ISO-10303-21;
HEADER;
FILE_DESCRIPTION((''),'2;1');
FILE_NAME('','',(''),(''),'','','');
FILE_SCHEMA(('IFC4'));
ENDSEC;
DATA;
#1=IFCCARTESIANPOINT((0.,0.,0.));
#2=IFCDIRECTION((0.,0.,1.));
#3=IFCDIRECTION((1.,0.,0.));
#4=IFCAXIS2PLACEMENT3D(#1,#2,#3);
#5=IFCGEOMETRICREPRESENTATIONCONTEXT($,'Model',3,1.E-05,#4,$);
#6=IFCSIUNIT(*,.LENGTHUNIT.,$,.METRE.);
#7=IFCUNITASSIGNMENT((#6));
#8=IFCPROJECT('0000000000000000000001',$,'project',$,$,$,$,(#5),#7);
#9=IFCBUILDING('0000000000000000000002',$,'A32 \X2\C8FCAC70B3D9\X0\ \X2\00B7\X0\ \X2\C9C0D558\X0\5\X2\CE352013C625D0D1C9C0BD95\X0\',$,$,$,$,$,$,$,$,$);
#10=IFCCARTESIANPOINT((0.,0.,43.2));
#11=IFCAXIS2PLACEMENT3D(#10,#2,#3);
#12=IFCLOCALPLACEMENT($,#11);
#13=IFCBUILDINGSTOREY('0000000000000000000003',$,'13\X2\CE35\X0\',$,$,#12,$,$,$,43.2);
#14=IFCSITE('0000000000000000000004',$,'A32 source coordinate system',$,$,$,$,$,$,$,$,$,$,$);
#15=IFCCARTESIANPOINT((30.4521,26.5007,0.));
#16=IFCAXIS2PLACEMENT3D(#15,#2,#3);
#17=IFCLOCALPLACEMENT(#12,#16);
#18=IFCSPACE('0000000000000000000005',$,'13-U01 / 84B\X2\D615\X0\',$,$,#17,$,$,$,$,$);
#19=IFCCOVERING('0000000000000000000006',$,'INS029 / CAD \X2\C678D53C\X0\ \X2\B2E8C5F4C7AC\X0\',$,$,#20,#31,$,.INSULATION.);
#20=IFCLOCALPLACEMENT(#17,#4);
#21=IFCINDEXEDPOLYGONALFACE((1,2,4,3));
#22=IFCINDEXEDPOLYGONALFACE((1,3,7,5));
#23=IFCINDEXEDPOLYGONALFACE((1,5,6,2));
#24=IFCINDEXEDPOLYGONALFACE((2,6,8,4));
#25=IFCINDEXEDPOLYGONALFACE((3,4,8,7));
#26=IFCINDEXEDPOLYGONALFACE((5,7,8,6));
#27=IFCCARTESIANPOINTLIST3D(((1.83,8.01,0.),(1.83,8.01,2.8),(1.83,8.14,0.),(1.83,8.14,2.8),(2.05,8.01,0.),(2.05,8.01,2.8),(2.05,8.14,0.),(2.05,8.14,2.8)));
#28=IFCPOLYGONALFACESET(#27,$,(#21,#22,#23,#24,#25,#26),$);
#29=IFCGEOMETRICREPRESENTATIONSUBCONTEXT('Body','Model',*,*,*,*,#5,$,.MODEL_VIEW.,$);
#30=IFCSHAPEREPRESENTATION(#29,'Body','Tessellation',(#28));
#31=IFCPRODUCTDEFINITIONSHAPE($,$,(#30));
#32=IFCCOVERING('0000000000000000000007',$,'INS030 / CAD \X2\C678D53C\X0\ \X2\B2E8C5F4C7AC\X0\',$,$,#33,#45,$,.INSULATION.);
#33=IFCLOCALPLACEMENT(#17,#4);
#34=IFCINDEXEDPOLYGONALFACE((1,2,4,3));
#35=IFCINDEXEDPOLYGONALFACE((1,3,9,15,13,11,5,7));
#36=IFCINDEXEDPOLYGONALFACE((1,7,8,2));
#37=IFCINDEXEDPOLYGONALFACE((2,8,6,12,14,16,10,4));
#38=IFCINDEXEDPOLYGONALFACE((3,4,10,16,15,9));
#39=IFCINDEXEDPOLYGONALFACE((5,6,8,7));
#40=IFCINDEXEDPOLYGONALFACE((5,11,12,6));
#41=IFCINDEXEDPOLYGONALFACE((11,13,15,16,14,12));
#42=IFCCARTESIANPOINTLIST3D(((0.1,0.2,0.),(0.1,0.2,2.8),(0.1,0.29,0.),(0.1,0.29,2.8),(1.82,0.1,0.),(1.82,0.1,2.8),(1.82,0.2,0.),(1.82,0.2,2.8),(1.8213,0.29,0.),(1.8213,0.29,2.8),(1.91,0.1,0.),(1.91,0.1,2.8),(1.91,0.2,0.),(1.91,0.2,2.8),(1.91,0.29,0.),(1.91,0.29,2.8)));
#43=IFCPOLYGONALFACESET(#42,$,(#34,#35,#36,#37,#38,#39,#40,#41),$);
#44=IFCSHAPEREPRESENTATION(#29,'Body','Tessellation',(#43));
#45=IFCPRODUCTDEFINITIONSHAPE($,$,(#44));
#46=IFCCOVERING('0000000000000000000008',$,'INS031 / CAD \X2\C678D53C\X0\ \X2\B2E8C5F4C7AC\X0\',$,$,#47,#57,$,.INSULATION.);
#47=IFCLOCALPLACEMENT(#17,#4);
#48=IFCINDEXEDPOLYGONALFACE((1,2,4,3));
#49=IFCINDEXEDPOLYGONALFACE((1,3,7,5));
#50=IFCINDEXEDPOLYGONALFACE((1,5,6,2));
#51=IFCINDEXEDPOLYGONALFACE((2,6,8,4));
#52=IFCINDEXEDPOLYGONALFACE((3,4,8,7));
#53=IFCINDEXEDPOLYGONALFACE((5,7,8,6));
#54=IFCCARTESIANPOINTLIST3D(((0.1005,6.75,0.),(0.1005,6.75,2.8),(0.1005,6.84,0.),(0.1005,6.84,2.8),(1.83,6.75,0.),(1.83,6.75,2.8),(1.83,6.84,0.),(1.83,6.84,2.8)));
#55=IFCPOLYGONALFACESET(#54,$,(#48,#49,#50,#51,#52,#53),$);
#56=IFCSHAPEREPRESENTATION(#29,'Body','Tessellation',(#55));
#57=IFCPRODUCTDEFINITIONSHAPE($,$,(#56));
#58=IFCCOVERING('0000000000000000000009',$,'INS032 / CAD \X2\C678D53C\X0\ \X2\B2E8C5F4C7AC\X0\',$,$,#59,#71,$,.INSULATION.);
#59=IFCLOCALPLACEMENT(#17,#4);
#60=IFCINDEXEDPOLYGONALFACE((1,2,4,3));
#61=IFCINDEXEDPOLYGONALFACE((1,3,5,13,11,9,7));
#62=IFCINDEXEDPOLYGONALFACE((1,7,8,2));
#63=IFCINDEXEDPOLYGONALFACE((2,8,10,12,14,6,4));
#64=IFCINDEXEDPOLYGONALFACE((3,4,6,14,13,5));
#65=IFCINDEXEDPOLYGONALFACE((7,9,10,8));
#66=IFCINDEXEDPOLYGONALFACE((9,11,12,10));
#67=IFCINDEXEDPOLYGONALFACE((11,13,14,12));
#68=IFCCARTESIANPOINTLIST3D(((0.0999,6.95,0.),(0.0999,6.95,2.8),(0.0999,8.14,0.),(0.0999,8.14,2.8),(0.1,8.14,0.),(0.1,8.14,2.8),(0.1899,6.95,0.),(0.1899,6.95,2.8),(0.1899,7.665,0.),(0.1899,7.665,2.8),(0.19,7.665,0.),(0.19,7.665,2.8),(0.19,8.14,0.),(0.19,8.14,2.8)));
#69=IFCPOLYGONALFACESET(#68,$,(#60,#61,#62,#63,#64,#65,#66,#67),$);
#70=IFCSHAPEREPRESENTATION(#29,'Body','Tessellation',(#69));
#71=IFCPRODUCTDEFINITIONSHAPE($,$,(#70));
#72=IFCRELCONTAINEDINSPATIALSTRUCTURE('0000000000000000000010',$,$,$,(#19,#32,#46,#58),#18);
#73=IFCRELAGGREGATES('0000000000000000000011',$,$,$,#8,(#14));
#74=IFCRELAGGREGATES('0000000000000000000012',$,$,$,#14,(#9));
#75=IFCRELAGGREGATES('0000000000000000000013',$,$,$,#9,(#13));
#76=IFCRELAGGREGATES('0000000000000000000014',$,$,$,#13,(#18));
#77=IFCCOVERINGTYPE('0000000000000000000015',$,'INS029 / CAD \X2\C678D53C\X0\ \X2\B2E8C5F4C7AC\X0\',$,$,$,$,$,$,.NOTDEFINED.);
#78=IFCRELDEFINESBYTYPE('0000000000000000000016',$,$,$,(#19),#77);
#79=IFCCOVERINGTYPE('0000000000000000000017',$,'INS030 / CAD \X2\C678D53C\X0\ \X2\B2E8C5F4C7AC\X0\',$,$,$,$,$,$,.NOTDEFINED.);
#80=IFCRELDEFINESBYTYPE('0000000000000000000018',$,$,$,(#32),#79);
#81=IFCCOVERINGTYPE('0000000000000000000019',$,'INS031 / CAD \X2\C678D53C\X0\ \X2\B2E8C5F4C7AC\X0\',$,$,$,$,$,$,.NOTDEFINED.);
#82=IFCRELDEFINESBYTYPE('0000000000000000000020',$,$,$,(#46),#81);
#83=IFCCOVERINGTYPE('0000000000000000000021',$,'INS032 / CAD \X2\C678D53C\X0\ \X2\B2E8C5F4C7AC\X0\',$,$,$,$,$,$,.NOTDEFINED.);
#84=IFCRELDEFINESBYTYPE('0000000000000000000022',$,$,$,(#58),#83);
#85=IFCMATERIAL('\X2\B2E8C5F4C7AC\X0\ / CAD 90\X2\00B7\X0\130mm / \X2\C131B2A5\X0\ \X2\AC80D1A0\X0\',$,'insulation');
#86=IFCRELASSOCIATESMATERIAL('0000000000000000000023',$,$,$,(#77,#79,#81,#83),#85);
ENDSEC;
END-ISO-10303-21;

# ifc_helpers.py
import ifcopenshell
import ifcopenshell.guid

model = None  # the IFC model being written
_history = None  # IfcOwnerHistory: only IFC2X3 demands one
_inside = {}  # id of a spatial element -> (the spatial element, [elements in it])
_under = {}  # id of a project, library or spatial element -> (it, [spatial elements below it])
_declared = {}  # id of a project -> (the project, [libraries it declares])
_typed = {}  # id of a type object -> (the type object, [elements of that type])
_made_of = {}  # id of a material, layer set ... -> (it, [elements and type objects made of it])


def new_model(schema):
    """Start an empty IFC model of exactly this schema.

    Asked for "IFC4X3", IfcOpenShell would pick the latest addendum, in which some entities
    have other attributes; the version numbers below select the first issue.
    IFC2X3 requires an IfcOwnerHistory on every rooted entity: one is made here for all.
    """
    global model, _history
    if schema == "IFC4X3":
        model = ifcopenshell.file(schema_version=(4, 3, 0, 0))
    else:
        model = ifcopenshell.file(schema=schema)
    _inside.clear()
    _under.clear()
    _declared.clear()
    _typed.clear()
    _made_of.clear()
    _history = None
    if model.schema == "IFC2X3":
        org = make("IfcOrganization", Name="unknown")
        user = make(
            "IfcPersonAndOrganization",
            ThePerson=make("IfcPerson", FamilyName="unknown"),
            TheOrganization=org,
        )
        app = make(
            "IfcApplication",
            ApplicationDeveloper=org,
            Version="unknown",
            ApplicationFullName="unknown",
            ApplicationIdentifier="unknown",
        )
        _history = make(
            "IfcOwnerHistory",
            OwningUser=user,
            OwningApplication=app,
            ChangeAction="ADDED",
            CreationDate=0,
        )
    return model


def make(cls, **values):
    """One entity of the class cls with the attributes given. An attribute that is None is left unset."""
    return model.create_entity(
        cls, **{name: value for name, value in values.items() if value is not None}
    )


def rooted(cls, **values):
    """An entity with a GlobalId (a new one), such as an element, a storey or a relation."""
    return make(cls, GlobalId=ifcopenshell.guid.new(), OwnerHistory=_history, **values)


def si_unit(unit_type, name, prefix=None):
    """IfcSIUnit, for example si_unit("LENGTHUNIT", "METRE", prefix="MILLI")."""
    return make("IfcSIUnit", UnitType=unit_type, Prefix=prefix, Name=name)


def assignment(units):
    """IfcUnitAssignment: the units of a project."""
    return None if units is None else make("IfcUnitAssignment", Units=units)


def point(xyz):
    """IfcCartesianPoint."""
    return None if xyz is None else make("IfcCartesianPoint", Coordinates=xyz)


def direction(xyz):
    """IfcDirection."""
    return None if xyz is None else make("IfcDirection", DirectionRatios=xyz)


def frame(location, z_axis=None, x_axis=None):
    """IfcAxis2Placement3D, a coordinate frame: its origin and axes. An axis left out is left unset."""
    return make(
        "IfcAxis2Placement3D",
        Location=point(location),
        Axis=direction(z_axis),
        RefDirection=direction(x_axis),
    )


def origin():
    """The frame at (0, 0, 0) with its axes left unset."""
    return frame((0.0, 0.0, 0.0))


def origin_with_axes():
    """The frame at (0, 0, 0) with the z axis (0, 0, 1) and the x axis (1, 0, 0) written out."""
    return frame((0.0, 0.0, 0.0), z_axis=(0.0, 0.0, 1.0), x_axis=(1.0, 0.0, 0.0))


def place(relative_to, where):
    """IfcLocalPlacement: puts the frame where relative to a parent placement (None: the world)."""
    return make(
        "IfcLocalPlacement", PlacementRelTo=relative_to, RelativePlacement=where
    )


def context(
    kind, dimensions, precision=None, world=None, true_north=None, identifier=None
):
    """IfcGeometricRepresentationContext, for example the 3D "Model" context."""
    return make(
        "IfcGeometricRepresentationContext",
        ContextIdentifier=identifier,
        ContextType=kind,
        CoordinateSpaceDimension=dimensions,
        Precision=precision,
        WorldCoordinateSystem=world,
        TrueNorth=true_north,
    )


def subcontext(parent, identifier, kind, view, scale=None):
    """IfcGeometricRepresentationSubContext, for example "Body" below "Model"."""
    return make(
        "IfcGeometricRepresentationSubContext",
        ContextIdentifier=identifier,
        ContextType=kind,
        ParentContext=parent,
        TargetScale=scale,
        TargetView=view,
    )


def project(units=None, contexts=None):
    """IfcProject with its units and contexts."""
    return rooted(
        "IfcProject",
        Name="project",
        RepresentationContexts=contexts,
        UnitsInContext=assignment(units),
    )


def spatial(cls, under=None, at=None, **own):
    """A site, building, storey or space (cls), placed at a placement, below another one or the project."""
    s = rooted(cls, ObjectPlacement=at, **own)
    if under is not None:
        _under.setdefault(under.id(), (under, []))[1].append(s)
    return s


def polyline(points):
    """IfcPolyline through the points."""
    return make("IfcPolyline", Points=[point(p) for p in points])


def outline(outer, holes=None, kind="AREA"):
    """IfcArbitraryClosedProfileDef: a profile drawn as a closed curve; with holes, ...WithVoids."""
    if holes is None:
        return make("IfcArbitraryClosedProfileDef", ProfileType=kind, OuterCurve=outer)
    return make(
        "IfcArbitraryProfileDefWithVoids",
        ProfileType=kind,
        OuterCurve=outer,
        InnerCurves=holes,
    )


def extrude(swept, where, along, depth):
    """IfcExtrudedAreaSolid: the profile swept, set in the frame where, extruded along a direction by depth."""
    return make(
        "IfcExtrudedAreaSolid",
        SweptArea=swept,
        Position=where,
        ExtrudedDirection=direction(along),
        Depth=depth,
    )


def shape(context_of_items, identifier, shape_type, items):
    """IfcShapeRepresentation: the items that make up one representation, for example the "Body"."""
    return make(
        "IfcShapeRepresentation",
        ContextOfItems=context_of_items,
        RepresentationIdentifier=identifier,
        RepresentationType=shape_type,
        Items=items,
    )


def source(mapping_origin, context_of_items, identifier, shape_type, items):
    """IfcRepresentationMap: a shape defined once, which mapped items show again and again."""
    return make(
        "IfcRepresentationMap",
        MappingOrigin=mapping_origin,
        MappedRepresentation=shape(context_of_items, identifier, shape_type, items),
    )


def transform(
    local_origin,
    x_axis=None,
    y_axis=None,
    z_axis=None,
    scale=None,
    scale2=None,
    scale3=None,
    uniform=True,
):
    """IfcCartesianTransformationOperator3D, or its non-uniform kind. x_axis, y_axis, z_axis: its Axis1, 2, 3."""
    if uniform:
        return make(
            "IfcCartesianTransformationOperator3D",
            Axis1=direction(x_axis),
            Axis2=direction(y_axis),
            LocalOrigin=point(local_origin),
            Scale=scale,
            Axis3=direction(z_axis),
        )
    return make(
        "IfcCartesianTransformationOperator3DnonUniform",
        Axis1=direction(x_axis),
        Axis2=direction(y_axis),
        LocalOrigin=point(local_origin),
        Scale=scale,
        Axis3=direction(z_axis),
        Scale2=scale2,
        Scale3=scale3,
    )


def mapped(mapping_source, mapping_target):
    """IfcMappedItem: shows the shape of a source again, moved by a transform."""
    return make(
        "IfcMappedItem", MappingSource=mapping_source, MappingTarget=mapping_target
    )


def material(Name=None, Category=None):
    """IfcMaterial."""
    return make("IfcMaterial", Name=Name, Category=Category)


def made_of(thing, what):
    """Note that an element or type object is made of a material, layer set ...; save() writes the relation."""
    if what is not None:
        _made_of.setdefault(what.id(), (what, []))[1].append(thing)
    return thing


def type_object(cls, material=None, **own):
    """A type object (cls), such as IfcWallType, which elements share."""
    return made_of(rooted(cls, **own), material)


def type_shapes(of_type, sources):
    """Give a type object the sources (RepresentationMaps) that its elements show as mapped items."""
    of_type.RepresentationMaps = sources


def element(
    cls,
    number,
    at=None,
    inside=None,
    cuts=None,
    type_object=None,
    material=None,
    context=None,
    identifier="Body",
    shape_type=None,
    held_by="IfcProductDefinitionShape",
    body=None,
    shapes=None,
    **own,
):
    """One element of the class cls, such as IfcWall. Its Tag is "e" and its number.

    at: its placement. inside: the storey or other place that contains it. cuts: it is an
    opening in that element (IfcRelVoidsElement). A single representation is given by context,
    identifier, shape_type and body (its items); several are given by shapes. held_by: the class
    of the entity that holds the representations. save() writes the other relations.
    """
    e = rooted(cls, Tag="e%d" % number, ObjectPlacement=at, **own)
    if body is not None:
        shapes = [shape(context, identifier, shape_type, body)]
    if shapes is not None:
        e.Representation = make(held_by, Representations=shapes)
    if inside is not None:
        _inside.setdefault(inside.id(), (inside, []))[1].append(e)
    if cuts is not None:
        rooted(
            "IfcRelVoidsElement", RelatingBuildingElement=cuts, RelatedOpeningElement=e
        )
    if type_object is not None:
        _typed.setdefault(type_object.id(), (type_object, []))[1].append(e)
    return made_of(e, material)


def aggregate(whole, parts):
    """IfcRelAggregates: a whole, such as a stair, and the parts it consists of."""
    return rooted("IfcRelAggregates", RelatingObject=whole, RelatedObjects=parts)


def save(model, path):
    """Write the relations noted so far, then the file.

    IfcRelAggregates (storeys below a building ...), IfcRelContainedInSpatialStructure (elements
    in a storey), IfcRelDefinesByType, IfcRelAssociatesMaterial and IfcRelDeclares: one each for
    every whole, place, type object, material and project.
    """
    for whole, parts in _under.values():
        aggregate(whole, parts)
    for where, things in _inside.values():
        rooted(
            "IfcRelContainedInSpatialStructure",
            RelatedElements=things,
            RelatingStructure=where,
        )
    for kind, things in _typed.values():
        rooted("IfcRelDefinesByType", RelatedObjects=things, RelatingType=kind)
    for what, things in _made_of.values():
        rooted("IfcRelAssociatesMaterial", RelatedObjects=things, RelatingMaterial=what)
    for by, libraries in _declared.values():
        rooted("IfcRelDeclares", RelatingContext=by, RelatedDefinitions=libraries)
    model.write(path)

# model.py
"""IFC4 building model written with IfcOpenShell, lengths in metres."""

from ifc_helpers import new_model, si_unit, frame, origin, origin_with_axes, place, context, subcontext, project, spatial, polyline, outline, extrude, source, transform, mapped, material, type_object, type_shapes, element, save


model = new_model("IFC4")

# Units and contexts
model_context = context("Model", 3, precision=1e-05, world=origin_with_axes())
body_context = subcontext(model_context, "Body", "Model", "MODEL_VIEW")
ifc_project = project(units=[si_unit("LENGTHUNIT", "METRE")], contexts=[model_context])

# Site, building, storey, space
storey_placement = place(None, frame((0.0, 0.0, 43.2), z_axis=(0.0, 0.0, 1.0), x_axis=(1.0, 0.0, 0.0)))
space_placement = place(storey_placement, frame((30.4521, 26.5007, 0.0), z_axis=(0.0, 0.0, 1.0), x_axis=(1.0, 0.0, 0.0)))
site = spatial("IfcSite", under=ifc_project, Name="A32 source coordinate system")
building = spatial("IfcBuilding", under=site, Name="A32 주거동 · 지하5층–옥탑지붕")
storey = spatial("IfcBuildingStorey", under=building, at=storey_placement, Name="13층", Elevation=43.2)
space = spatial("IfcSpace", under=storey, at=space_placement, Name="13-U01 / 84B형")

# Coverings
ifc_material = material(Name="단열재 / CAD 90·130mm / 성능 검토", Category="insulation")
covering_type_1 = type_object("IfcCoveringType", Name="INS029 / CAD 외피 단열재", PredefinedType="NOTDEFINED", material=ifc_material)
shared_shape_1 = source(origin(), body_context, "Body", "SweptSolid", [
    extrude(outline(polyline([(1.83, 8.01), (1.83, 8.14), (2.05, 8.14), (2.05, 8.01), (1.83, 8.01)])), origin(), (0.0, 0.0, 1.0), 2.8),
])
type_shapes(covering_type_1, [shared_shape_1])
covering_1_placement = place(space_placement, origin_with_axes())
element("IfcCovering", 1, at=covering_1_placement, inside=space, type_object=covering_type_1, Name="INS029 / CAD 외피 단열재", PredefinedType="INSULATION", context=body_context, shape_type="MappedRepresentation", body=[
    mapped(shared_shape_1, transform((0.0, 0.0, 0.0), scale=1.0)),
])
covering_type_2 = type_object("IfcCoveringType", Name="INS030 / CAD 외피 단열재", PredefinedType="NOTDEFINED", material=ifc_material)
shared_shape_2 = source(origin(), body_context, "Body", "SweptSolid", [
    extrude(outline(polyline([(1.91, 0.2), (1.91, 0.1), (1.82, 0.1), (1.82, 0.2), (0.1, 0.2), (0.1, 0.29), (1.8213, 0.29), (1.91, 0.29), (1.91, 0.2)])), origin(), (0.0, 0.0, 1.0), 2.8),
])
type_shapes(covering_type_2, [shared_shape_2])
covering_2_placement = place(space_placement, origin_with_axes())
element("IfcCovering", 2, at=covering_2_placement, inside=space, type_object=covering_type_2, Name="INS030 / CAD 외피 단열재", PredefinedType="INSULATION", context=body_context, shape_type="MappedRepresentation", body=[
    mapped(shared_shape_2, transform((0.0, 0.0, 0.0), scale=1.0)),
])
covering_type_3 = type_object("IfcCoveringType", Name="INS031 / CAD 외피 단열재", PredefinedType="NOTDEFINED", material=ifc_material)
shared_shape_3 = source(origin(), body_context, "Body", "SweptSolid", [
    extrude(outline(polyline([(1.83, 6.75), (0.1005, 6.75), (0.1005, 6.84), (1.83, 6.84), (1.83, 6.75)])), origin(), (0.0, 0.0, 1.0), 2.8),
])
type_shapes(covering_type_3, [shared_shape_3])
covering_3_placement = place(space_placement, origin_with_axes())
element("IfcCovering", 3, at=covering_3_placement, inside=space, type_object=covering_type_3, Name="INS031 / CAD 외피 단열재", PredefinedType="INSULATION", context=body_context, shape_type="MappedRepresentation", body=[
    mapped(shared_shape_3, transform((0.0, 0.0, 0.0), scale=1.0)),
])
covering_type_4 = type_object("IfcCoveringType", Name="INS032 / CAD 외피 단열재", PredefinedType="NOTDEFINED", material=ifc_material)
shared_shape_4 = source(origin(), body_context, "Body", "SweptSolid", [
    extrude(outline(polyline([(0.1899, 6.95), (0.0999, 6.95), (0.0999, 8.14), (0.1, 8.14), (0.19, 8.14), (0.19, 7.665), (0.1899, 7.665), (0.1899, 6.95)])), origin(), (0.0, 0.0, 1.0), 2.8),
])
type_shapes(covering_type_4, [shared_shape_4])
covering_4_placement = place(space_placement, origin_with_axes())
element("IfcCovering", 4, at=covering_4_placement, inside=space, type_object=covering_type_4, Name="INS032 / CAD 외피 단열재", PredefinedType="INSULATION", context=body_context, shape_type="MappedRepresentation", body=[
    mapped(shared_shape_4, transform((0.0, 0.0, 0.0), scale=1.0)),
])

save(model, "model.ifc")
